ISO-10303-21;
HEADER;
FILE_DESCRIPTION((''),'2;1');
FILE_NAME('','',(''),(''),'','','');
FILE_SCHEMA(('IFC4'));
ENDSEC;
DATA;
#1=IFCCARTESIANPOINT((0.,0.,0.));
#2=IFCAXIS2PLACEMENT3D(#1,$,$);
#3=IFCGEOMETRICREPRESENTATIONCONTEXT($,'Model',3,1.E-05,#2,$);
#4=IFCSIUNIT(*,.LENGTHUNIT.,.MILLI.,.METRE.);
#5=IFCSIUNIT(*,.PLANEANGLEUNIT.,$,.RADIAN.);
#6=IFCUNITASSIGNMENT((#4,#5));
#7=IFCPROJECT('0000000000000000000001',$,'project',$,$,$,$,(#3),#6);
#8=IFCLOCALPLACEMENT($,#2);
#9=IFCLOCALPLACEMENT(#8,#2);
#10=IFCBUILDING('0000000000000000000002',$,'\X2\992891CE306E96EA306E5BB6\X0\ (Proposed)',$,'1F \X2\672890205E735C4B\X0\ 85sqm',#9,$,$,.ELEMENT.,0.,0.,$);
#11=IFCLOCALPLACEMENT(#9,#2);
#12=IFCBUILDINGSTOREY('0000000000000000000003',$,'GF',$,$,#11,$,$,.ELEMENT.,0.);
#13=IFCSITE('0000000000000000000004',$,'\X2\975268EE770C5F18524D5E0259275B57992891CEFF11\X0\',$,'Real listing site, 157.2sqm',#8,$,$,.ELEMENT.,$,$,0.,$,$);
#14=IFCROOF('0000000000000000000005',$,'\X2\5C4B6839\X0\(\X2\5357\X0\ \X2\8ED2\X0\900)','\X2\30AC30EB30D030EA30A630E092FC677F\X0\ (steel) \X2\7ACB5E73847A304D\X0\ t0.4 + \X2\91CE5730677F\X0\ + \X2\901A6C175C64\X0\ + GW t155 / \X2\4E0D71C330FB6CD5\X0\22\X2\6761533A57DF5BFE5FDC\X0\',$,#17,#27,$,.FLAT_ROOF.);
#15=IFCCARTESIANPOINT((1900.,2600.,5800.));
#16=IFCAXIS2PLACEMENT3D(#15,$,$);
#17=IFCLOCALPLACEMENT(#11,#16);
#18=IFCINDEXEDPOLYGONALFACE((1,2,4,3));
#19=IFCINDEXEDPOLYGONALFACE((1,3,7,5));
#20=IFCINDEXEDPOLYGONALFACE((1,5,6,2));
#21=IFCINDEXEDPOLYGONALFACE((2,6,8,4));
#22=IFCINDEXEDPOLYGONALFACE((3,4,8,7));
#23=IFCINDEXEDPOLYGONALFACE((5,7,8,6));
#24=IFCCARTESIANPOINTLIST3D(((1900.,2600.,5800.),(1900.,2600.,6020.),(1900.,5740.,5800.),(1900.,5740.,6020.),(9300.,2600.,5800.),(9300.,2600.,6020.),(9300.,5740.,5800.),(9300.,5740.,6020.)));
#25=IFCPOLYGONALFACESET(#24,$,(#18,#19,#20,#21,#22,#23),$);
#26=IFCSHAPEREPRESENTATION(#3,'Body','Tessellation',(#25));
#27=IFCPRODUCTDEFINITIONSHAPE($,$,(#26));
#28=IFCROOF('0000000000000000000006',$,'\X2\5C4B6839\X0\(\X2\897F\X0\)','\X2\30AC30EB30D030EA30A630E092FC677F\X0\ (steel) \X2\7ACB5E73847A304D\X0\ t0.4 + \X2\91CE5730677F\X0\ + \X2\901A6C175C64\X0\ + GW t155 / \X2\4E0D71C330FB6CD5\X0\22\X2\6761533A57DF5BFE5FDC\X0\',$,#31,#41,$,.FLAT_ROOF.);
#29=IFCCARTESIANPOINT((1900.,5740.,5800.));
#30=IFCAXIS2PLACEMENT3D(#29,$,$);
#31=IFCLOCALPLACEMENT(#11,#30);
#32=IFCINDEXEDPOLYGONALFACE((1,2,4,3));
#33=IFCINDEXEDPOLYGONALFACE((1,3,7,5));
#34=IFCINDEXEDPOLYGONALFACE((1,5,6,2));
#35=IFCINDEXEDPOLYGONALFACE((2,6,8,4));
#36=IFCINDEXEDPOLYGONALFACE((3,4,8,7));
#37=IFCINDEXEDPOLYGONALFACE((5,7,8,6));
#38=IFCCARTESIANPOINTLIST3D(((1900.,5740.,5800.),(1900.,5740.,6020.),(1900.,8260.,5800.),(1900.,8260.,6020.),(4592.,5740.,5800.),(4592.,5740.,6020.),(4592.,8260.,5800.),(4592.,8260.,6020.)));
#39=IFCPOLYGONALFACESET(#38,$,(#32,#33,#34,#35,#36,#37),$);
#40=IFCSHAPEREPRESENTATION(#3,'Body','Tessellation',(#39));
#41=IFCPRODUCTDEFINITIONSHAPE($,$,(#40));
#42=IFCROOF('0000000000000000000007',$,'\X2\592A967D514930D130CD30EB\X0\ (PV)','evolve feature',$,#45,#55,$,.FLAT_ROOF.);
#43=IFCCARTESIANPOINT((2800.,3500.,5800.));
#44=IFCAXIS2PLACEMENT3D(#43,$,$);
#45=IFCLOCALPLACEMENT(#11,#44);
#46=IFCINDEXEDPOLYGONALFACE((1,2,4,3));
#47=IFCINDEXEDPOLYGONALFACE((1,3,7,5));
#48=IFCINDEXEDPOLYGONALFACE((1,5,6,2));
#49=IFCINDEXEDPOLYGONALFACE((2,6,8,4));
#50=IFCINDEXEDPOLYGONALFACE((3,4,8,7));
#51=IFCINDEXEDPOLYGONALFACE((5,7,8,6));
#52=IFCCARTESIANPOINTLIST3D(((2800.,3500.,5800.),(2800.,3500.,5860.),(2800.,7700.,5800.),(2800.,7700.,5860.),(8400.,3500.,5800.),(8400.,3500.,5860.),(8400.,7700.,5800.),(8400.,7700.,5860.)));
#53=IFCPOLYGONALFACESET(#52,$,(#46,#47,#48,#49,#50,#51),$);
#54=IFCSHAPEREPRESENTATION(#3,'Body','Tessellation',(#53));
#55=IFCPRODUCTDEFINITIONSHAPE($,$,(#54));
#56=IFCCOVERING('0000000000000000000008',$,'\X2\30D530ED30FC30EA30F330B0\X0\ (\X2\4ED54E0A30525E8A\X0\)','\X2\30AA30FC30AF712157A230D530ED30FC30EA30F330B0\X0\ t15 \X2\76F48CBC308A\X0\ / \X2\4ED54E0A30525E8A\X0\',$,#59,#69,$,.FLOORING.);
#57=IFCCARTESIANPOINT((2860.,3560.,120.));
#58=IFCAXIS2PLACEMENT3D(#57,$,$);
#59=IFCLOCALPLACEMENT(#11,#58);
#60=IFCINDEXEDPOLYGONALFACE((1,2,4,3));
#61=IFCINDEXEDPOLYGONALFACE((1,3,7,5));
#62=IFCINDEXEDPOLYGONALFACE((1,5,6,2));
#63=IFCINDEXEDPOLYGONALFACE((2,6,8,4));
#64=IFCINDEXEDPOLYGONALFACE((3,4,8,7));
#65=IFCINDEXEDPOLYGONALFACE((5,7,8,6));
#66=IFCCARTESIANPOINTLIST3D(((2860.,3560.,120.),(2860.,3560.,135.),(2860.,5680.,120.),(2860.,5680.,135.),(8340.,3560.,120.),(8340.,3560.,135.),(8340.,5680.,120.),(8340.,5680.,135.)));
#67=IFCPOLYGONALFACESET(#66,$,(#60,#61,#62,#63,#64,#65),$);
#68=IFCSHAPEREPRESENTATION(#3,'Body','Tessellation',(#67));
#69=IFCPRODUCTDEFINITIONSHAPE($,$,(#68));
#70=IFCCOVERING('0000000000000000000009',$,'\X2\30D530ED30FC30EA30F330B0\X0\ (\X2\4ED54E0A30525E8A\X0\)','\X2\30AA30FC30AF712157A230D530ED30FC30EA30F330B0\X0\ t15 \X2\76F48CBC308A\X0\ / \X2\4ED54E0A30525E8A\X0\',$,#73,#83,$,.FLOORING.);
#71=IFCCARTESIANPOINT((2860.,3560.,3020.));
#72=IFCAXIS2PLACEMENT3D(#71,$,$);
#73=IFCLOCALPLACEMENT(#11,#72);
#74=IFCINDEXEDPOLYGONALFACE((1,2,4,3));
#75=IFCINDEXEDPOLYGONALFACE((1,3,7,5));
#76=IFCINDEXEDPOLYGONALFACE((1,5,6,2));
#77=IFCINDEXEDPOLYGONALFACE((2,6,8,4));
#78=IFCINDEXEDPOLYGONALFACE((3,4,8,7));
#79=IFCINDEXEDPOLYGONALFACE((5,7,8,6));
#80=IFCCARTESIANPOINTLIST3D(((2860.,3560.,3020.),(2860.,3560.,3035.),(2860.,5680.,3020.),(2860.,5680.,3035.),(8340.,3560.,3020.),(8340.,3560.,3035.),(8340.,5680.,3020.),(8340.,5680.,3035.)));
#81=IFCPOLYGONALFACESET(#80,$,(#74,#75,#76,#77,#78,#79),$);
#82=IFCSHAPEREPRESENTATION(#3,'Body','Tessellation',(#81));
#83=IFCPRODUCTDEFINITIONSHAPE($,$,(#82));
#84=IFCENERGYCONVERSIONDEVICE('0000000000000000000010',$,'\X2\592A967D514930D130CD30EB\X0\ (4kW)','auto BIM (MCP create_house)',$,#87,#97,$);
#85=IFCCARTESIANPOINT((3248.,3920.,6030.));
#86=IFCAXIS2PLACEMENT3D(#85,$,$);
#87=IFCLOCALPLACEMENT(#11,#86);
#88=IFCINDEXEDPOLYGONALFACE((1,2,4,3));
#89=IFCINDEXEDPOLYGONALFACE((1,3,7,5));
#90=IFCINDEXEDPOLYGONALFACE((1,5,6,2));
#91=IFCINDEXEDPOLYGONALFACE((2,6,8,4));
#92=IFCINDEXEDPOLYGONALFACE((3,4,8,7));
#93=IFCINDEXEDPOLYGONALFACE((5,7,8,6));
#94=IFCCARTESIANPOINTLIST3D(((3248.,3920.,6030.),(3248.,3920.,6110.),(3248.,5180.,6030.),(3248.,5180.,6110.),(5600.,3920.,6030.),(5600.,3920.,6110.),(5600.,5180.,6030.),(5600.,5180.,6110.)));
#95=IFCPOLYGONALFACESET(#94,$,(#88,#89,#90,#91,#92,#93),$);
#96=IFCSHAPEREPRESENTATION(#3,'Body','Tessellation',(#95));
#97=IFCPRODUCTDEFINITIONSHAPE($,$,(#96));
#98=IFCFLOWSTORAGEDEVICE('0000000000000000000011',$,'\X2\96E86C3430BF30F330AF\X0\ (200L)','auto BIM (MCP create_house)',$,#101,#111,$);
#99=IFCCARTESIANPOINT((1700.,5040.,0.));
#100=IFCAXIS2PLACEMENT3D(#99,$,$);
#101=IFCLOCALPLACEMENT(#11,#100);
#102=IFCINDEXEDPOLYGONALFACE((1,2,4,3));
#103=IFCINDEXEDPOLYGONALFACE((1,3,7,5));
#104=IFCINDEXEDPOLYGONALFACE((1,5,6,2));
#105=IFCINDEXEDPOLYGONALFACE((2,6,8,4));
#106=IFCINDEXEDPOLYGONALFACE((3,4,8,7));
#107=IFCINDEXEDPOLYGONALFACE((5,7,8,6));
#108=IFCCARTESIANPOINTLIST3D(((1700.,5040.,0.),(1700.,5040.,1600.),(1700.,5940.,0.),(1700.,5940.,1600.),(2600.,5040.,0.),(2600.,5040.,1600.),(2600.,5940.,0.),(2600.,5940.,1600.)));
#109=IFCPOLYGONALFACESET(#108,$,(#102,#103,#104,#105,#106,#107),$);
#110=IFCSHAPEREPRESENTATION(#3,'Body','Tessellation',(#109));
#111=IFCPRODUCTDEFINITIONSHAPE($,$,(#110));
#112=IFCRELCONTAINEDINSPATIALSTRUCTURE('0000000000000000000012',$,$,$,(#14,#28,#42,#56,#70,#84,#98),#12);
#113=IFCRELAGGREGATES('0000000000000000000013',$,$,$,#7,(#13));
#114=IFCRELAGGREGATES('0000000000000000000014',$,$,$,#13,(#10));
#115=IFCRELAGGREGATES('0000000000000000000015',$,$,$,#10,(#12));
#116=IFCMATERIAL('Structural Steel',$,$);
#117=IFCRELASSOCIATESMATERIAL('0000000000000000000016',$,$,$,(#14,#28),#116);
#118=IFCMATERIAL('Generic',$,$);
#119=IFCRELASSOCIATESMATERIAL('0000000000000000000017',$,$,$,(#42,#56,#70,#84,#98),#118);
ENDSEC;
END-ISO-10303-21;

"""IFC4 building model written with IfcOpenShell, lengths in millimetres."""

from ifc_helpers import new_model, si_unit, frame, frame_2d, origin, place, context, project, spatial, rectangle, extrude, material, element, save


model = new_model("IFC4")

# Units and contexts
model_context = context("Model", 3, precision=1e-05, world=origin())
ifc_project = project(units=[si_unit("LENGTHUNIT", "METRE", prefix="MILLI"), si_unit("PLANEANGLEUNIT", "RADIAN")], contexts=[model_context])

# Site, building, storey
site_placement = place(None, origin())
site = spatial("IfcSite", under=ifc_project, at=site_placement, Name="青森県弘前市大字館野１", ObjectType="Real listing site, 157.2sqm", CompositionType="ELEMENT", RefElevation=0.0)
building_placement = place(site_placement, origin())
building = spatial("IfcBuilding", under=site, at=building_placement, Name="館野の雪の家 (Proposed)", ObjectType="1F 木造平屋 85sqm", CompositionType="ELEMENT", ElevationOfRefHeight=0.0, ElevationOfTerrain=0.0)
storey_placement = place(building_placement, origin())
storey = spatial("IfcBuildingStorey", under=building, at=storey_placement, Name="GF", CompositionType="ELEMENT", Elevation=0.0)

# Shared definitions
ifc_material_1 = material(Name="Generic")

# Roofs
ifc_material_2 = material(Name="Structural Steel")
roof_1_placement = place(storey_placement, frame((1900.0, 2600.0, 5800.0)))
element("IfcRoof", 1, at=roof_1_placement, inside=storey, material=ifc_material_2, Name="屋根(南 軒900)", Description="ガルバリウム鋼板 (steel) 立平葺き t0.4 + 野地板 + 通気層 + GW t155 / 不燃・法22条区域対応", PredefinedType="FLAT_ROOF", context=model_context, shape_type="SweptSolid", body=[
    extrude(rectangle(XDim=7400.0, YDim=3140.0, at=frame_2d((3700.0, 1570.0))), frame((1900.0, 2600.0, 5800.0)), (0.0, 0.0, 1.0), 220.0),
])
roof_2_placement = place(storey_placement, frame((1900.0, 5740.0, 5800.0)))
element("IfcRoof", 2, at=roof_2_placement, inside=storey, material=ifc_material_2, Name="屋根(西)", Description="ガルバリウム鋼板 (steel) 立平葺き t0.4 + 野地板 + 通気層 + GW t155 / 不燃・法22条区域対応", PredefinedType="FLAT_ROOF", context=model_context, shape_type="SweptSolid", body=[
    extrude(rectangle(XDim=2692.0, YDim=2520.0, at=frame_2d((1346.0, 1260.0))), frame((1900.0, 5740.0, 5800.0)), (0.0, 0.0, 1.0), 220.0),
])
roof_3_placement = place(storey_placement, frame((2800.0, 3500.0, 5800.0)))
element("IfcRoof", 3, at=roof_3_placement, inside=storey, material=ifc_material_1, Name="太陽光パネル (PV)", Description="evolve feature", PredefinedType="FLAT_ROOF", context=model_context, shape_type="SweptSolid", body=[
    extrude(rectangle(XDim=5600.0, YDim=4200.0, at=frame_2d((2800.0, 2100.0))), frame((2800.0, 3500.0, 5800.0)), (0.0, 0.0, 1.0), 60.0),
])

# Coverings
covering_1_placement = place(storey_placement, frame((2860.0, 3560.0, 120.0)))
element("IfcCovering", 4, at=covering_1_placement, inside=storey, material=ifc_material_1, Name="フローリング (仕上げ床)", Description="オーク無垢フローリング t15 直貼り / 仕上げ床", PredefinedType="FLOORING", context=model_context, shape_type="SweptSolid", body=[
    extrude(rectangle(XDim=5480.0, YDim=2120.0, at=frame_2d((2740.0, 1060.0))), frame((2860.0, 3560.0, 120.0)), (0.0, 0.0, 1.0), 15.0),
])
covering_2_placement = place(storey_placement, frame((2860.0, 3560.0, 3020.0)))
element("IfcCovering", 5, at=covering_2_placement, inside=storey, material=ifc_material_1, Name="フローリング (仕上げ床)", Description="オーク無垢フローリング t15 直貼り / 仕上げ床", PredefinedType="FLOORING", context=model_context, shape_type="SweptSolid", body=[
    extrude(rectangle(XDim=5480.0, YDim=2120.0, at=frame_2d((2740.0, 1060.0))), frame((2860.0, 3560.0, 3020.0)), (0.0, 0.0, 1.0), 15.0),
])

# Energy conversion device
energy_conversion_device_placement = place(storey_placement, frame((3248.0, 3920.0, 6030.0)))
element("IfcEnergyConversionDevice", 6, at=energy_conversion_device_placement, inside=storey, material=ifc_material_1, Name="太陽光パネル (4kW)", Description="auto BIM (MCP create_house)", context=model_context, shape_type="SweptSolid", body=[
    extrude(rectangle(XDim=2352.0, YDim=1260.0, at=frame_2d((1176.0, 630.0))), frame((3248.0, 3920.0, 6030.0)), (0.0, 0.0, 1.0), 80.0),
])

# Flow storage device
flow_storage_device_placement = place(storey_placement, frame((1700.0, 5040.0, 0.0)))
element("IfcFlowStorageDevice", 7, at=flow_storage_device_placement, inside=storey, material=ifc_material_1, Name="雨水タンク (200L)", Description="auto BIM (MCP create_house)", context=model_context, shape_type="SweptSolid", body=[
    extrude(rectangle(XDim=900.0, YDim=900.0, at=frame_2d((450.0, 450.0))), frame((1700.0, 5040.0, 0.0)), (0.0, 0.0, 1.0), 1600.0),
])

save(model, "model.ifc")
